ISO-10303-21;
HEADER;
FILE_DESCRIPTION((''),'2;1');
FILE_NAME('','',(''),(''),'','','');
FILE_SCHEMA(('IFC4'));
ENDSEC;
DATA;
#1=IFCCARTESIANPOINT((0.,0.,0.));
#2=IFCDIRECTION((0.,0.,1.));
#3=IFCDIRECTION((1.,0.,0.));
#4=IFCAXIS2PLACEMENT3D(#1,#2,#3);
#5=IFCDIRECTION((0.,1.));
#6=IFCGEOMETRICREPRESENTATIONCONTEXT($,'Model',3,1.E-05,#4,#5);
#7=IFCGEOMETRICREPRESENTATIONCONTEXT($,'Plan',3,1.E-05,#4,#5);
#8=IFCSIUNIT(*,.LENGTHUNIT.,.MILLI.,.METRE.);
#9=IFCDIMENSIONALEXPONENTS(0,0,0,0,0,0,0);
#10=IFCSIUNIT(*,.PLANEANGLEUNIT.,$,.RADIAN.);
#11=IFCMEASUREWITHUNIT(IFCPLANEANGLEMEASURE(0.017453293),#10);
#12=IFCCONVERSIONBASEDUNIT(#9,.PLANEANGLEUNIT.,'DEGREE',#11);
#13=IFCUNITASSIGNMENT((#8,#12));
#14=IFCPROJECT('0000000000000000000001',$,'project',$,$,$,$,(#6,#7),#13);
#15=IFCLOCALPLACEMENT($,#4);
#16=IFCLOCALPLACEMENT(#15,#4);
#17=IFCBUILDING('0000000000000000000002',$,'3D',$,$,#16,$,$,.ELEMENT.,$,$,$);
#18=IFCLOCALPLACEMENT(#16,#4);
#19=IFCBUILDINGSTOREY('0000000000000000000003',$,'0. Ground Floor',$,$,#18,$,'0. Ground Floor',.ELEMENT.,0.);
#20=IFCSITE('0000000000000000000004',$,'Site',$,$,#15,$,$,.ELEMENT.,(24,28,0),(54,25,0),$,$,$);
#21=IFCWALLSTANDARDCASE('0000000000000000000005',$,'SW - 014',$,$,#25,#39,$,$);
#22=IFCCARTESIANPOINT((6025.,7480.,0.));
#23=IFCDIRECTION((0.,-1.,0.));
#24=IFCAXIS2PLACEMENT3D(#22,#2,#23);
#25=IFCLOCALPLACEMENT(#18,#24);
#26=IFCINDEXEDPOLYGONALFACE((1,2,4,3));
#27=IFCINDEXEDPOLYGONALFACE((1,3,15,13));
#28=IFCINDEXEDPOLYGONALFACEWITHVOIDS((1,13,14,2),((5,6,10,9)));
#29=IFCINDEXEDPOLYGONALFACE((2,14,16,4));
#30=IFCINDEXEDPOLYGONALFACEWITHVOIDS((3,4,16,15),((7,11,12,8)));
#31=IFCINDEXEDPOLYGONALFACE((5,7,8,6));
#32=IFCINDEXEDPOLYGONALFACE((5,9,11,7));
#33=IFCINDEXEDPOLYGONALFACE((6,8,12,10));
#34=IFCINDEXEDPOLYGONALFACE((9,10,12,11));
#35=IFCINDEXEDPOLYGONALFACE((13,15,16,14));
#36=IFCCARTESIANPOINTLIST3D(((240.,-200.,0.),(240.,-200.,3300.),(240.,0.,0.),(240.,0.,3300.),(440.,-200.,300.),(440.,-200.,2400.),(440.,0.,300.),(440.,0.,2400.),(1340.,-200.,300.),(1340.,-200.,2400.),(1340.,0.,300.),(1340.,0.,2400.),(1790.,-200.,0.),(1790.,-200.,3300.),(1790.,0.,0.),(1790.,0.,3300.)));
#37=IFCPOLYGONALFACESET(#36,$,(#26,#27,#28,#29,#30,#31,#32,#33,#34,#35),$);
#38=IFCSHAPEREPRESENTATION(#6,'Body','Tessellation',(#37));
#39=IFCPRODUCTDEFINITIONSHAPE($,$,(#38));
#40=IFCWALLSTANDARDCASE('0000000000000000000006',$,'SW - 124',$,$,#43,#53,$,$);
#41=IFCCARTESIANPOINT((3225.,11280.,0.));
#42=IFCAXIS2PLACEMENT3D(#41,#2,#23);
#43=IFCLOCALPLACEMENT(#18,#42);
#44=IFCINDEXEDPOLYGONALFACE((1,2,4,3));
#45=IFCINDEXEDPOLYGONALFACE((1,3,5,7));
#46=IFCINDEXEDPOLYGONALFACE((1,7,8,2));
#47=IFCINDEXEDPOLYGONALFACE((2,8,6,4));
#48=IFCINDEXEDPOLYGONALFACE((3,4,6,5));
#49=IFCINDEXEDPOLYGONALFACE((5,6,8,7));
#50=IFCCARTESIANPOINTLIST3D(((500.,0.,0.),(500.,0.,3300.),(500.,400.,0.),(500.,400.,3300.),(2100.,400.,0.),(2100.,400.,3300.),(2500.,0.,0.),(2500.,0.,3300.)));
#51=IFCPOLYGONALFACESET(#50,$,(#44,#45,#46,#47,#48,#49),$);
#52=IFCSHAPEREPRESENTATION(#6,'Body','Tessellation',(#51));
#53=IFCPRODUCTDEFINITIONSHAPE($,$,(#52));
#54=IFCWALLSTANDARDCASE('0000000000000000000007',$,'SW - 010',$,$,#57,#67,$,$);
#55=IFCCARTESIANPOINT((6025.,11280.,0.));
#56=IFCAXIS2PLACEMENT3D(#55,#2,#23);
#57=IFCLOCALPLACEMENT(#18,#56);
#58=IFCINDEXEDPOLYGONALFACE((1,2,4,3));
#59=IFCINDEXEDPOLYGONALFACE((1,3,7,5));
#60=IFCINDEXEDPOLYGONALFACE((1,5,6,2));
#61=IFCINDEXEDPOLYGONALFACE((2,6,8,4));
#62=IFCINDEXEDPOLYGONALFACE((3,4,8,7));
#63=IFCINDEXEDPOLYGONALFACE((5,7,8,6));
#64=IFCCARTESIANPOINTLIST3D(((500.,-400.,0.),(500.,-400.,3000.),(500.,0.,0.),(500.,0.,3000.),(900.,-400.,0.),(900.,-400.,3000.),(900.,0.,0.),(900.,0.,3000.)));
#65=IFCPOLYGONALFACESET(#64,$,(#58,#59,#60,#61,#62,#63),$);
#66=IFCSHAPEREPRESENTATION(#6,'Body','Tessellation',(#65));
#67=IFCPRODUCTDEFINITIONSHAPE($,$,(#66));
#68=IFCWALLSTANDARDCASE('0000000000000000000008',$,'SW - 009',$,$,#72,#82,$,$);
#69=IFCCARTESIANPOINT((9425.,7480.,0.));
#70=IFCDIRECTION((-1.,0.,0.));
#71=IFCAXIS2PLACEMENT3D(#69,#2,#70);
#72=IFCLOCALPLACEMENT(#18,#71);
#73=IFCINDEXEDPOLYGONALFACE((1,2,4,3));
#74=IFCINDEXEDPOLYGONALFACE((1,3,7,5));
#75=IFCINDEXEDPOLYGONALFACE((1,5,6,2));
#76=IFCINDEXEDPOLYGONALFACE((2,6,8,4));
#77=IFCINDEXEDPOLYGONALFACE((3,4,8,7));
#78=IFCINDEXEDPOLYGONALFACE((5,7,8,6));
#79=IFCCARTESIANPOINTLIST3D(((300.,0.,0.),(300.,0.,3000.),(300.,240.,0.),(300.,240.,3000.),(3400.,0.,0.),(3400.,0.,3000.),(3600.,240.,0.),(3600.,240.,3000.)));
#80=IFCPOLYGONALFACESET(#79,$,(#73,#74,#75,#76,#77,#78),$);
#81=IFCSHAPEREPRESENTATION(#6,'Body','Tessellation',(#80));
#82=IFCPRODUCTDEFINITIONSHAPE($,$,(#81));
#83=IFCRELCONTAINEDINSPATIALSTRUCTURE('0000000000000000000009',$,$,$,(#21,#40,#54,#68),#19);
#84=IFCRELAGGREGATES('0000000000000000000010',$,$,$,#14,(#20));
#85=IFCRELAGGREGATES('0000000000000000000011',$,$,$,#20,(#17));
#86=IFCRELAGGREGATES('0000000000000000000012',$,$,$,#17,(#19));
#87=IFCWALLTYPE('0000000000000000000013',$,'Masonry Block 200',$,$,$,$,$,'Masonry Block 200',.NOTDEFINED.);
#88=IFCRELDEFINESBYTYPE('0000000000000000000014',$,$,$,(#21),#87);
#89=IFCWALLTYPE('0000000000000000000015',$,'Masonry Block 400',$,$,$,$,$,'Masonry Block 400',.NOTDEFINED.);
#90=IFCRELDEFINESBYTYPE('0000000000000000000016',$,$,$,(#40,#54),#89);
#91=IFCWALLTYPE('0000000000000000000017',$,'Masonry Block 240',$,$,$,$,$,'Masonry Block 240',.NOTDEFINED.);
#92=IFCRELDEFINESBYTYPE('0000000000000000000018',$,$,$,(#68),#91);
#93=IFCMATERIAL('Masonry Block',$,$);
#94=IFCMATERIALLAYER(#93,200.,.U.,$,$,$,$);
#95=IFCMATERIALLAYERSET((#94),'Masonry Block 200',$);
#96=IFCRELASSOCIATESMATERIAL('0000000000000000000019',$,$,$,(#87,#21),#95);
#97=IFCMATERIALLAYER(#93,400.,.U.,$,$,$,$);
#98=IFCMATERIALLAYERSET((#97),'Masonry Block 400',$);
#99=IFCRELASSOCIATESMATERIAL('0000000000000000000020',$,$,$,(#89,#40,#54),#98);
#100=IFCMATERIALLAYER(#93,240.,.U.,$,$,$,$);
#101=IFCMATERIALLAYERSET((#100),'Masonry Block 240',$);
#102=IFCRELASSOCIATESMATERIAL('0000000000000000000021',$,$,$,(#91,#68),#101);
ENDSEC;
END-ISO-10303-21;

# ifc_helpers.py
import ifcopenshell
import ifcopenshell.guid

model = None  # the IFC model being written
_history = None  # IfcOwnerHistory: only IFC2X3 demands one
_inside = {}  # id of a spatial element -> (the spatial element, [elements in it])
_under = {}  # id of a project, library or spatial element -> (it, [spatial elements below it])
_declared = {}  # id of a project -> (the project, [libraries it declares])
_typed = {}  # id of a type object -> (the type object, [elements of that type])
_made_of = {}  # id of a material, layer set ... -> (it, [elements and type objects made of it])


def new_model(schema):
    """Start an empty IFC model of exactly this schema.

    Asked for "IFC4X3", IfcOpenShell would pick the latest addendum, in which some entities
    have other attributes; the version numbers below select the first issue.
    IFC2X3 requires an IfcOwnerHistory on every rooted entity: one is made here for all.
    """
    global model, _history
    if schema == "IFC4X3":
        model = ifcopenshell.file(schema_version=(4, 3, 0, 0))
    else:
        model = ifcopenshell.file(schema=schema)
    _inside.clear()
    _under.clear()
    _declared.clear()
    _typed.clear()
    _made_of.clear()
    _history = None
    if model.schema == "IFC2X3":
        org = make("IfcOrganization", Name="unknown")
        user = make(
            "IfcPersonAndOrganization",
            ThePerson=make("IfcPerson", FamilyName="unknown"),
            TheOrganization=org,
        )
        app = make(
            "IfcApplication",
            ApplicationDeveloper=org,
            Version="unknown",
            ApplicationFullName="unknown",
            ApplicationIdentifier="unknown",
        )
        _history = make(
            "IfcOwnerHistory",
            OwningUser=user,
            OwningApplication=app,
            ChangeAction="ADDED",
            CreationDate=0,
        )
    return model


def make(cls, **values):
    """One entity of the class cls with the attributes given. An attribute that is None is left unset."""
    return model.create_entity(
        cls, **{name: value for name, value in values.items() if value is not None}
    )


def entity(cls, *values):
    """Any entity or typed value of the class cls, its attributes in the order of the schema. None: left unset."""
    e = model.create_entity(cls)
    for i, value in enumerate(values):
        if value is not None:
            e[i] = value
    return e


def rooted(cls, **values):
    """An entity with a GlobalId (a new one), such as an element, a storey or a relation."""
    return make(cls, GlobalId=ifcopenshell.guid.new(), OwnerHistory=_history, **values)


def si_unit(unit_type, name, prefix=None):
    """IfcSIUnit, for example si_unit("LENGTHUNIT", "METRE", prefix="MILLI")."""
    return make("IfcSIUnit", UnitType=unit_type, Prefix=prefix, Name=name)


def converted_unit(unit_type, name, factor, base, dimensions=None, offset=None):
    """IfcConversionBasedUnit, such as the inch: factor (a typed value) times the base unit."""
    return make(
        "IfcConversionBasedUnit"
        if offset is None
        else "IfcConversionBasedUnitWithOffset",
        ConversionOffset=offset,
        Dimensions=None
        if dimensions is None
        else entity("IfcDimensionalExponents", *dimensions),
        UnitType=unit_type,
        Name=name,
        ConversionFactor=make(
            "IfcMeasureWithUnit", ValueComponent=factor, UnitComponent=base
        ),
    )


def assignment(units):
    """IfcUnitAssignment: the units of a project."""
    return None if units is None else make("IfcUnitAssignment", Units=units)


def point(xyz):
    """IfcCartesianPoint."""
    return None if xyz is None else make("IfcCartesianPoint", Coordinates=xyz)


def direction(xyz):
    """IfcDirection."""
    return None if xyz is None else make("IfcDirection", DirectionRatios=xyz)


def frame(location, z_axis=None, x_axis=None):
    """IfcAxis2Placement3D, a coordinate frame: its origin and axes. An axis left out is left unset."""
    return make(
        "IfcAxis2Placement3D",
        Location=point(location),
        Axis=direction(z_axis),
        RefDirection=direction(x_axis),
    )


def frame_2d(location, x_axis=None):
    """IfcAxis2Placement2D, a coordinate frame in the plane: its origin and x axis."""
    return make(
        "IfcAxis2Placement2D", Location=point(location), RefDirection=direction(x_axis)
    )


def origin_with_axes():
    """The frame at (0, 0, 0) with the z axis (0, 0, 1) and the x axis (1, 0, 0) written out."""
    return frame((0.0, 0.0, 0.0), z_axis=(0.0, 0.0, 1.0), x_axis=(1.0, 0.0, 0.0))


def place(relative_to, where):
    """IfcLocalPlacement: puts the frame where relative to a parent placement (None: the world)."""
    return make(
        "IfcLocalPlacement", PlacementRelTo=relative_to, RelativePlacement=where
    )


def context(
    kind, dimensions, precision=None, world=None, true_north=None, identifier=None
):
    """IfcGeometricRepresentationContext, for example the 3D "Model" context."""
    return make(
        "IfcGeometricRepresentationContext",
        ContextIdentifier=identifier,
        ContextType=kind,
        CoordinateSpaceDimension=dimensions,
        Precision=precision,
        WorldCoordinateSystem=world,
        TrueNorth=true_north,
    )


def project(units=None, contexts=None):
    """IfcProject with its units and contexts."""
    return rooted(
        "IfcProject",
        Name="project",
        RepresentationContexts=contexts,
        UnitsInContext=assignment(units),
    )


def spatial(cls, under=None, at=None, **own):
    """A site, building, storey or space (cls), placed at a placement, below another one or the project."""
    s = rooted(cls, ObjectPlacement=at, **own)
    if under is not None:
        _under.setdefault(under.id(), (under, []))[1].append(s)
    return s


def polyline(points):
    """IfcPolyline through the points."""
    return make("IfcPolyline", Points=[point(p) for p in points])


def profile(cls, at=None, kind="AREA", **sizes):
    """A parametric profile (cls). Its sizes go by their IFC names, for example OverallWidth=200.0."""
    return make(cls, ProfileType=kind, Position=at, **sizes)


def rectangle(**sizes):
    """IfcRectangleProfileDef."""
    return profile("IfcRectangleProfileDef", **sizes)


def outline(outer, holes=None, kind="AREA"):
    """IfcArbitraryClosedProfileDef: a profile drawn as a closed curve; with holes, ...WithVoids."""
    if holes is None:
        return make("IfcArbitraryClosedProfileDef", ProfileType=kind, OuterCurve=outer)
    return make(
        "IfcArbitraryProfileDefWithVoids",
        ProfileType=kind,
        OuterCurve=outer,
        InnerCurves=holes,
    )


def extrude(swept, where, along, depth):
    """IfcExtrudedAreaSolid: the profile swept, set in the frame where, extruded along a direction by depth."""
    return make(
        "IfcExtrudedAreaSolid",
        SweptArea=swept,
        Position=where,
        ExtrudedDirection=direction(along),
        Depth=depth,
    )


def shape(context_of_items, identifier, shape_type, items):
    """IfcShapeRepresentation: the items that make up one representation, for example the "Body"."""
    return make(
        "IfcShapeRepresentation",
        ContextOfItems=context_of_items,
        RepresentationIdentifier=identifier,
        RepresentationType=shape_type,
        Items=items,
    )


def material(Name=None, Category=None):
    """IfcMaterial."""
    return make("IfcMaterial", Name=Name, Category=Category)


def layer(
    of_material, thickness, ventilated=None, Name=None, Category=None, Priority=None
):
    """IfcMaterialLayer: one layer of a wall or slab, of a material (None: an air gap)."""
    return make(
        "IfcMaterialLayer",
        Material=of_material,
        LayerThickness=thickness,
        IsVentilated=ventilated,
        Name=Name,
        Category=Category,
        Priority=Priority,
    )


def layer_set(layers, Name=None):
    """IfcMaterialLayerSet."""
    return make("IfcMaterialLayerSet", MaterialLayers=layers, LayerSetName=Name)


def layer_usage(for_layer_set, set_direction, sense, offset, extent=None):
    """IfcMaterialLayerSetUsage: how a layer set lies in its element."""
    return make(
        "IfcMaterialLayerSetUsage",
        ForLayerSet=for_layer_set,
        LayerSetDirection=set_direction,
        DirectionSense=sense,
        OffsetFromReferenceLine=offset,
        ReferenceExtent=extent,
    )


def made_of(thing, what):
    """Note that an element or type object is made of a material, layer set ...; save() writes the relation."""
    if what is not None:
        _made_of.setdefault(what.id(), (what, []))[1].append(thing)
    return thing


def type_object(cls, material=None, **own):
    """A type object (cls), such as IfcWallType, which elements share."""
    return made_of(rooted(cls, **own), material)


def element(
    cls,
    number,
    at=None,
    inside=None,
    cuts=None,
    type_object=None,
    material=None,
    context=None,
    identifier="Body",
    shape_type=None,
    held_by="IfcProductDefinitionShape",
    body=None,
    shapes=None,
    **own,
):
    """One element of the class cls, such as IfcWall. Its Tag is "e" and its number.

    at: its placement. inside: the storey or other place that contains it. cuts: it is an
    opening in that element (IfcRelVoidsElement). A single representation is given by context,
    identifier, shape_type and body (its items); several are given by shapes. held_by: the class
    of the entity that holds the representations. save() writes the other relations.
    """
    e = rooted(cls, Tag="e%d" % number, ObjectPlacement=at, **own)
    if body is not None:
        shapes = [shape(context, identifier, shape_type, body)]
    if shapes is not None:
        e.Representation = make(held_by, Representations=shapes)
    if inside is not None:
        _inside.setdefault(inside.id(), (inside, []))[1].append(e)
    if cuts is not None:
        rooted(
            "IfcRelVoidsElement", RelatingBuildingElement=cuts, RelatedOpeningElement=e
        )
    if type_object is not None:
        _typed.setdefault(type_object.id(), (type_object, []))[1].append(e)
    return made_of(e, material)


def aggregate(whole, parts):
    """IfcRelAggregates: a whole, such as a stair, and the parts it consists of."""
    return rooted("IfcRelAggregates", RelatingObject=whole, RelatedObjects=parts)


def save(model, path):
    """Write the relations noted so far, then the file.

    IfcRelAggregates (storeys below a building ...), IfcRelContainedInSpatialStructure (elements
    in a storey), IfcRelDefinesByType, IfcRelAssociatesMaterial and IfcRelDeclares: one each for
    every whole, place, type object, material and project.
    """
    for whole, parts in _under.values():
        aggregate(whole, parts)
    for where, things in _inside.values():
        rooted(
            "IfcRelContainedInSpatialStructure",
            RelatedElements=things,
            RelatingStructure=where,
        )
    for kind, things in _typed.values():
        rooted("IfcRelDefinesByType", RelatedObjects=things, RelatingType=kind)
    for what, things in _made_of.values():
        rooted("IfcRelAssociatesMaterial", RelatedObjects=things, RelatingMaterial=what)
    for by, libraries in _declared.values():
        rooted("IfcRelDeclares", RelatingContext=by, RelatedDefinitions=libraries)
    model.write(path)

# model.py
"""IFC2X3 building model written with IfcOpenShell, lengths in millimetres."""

from ifc_helpers import new_model, entity, si_unit, converted_unit, direction, frame, frame_2d, origin_with_axes, place, context, project, spatial, polyline, rectangle, outline, extrude, material, layer, layer_set, layer_usage, type_object, element, save


model = new_model("IFC2X3")

# Units and contexts
model_context = context("Model", 3, precision=1e-05, world=origin_with_axes(), true_north=direction((0.0, 1.0)))
plan_context = context("Plan", 3, precision=1e-05, world=origin_with_axes(), true_north=direction((0.0, 1.0)))
ifc_project = project(units=[si_unit("LENGTHUNIT", "METRE", prefix="MILLI"), converted_unit("PLANEANGLEUNIT", "DEGREE", entity("IfcPlaneAngleMeasure", 0.017453293), si_unit("PLANEANGLEUNIT", "RADIAN"), dimensions=[0, 0, 0, 0, 0, 0, 0])], contexts=[model_context, plan_context])

# Site, building, storey
site_placement = place(None, origin_with_axes())
site = spatial("IfcSite", under=ifc_project, at=site_placement, Name="Site", CompositionType="ELEMENT", RefLatitude=(24, 28, 0), RefLongitude=(54, 25, 0))
building_placement = place(site_placement, origin_with_axes())
building = spatial("IfcBuilding", under=site, at=building_placement, Name="3D", CompositionType="ELEMENT")
storey_placement = place(building_placement, origin_with_axes())
storey = spatial("IfcBuildingStorey", under=building, at=storey_placement, Name="0. Ground Floor", LongName="0. Ground Floor", CompositionType="ELEMENT", Elevation=0.0)

# Shared definitions
ifc_material_1 = material(Name="Masonry Block")
ifc_layer_1 = layer(ifc_material_1, 200.0, ventilated="UNKNOWN")
ifc_layer_set_1 = layer_set([ifc_layer_1], Name="Masonry Block 200")

# Wall, opening
wall_type_1 = type_object("IfcWallType", Name="Masonry Block 200", ElementType="Masonry Block 200", PredefinedType="NOTDEFINED", material=ifc_layer_set_1)
ifc_layer_usage_1 = layer_usage(ifc_layer_set_1, "AXIS2", "NEGATIVE", 0.0)
wall_1_placement = place(storey_placement, frame((6025.0, 7480.0, 0.0), z_axis=(0.0, 0.0, 1.0), x_axis=(0.0, -1.0, 0.0)))
wall_1 = element("IfcWallStandardCase", 1, at=wall_1_placement, inside=storey, type_object=wall_type_1, material=ifc_layer_usage_1, Name="SW - 014", context=model_context, shape_type="SweptSolid", body=[
    extrude(outline(polyline([(240.0, -200.0), (1790.0, -200.0), (1790.0, 0.0), (240.0, 0.0), (240.0, -200.0)])), origin_with_axes(), (0.0, 0.0, 1.0), 3300.0),
])
opening_1_placement = place(wall_1_placement, frame((890.0, -200.0, 300.0), z_axis=(0.0, 0.0, 1.0), x_axis=(1.0, 0.0, 0.0)))
element("IfcOpeningElement", 2, at=opening_1_placement, cuts=wall_1, ObjectType="Opening", context=model_context, shape_type="SweptSolid", body=[
    extrude(rectangle(XDim=900.0, YDim=2100.0, at=frame_2d((0.0, 1050.0), x_axis=(1.0, 0.0))), frame((0.0, 0.0, 0.0), z_axis=(0.0, 1.0, 0.0), x_axis=(-1.0, 0.0, 0.0)), (0.0, 0.0, 1.0), 200.0),
])

# Walls
ifc_layer_2 = layer(ifc_material_1, 400.0, ventilated="UNKNOWN")
ifc_layer_set_2 = layer_set([ifc_layer_2], Name="Masonry Block 400")
ifc_layer_usage_2 = layer_usage(ifc_layer_set_2, "AXIS2", "POSITIVE", 0.0)
wall_type_2 = type_object("IfcWallType", Name="Masonry Block 400", ElementType="Masonry Block 400", PredefinedType="NOTDEFINED", material=ifc_layer_set_2)
wall_2_placement = place(storey_placement, frame((3225.0, 11280.0, 0.0), z_axis=(0.0, 0.0, 1.0), x_axis=(0.0, -1.0, 0.0)))
element("IfcWallStandardCase", 3, at=wall_2_placement, inside=storey, type_object=wall_type_2, material=ifc_layer_usage_2, Name="SW - 124", context=model_context, shape_type="SweptSolid", body=[
    extrude(outline(polyline([(500.0, 0.0), (2500.0, 0.0), (2100.0, 400.0), (500.0, 400.0), (500.0, 0.0)])), origin_with_axes(), (0.0, 0.0, 1.0), 3300.0),
])
ifc_layer_usage_3 = layer_usage(ifc_layer_set_2, "AXIS2", "NEGATIVE", 0.0)
wall_3_placement = place(storey_placement, frame((6025.0, 11280.0, 0.0), z_axis=(0.0, 0.0, 1.0), x_axis=(0.0, -1.0, 0.0)))
element("IfcWallStandardCase", 4, at=wall_3_placement, inside=storey, type_object=wall_type_2, material=ifc_layer_usage_3, Name="SW - 010", context=model_context, shape_type="SweptSolid", body=[
    extrude(outline(polyline([(500.0, -400.0), (900.0, -400.0), (900.0, 0.0), (500.0, 0.0), (500.0, -400.0)])), origin_with_axes(), (0.0, 0.0, 1.0), 3000.0),
])
ifc_layer_3 = layer(ifc_material_1, 240.0, ventilated="UNKNOWN")
ifc_layer_set_3 = layer_set([ifc_layer_3], Name="Masonry Block 240")
wall_type_3 = type_object("IfcWallType", Name="Masonry Block 240", ElementType="Masonry Block 240", PredefinedType="NOTDEFINED", material=ifc_layer_set_3)
ifc_layer_usage_4 = layer_usage(ifc_layer_set_3, "AXIS2", "POSITIVE", 0.0)
wall_4_placement = place(storey_placement, frame((9425.0, 7480.0, 0.0), z_axis=(0.0, 0.0, 1.0), x_axis=(-1.0, 0.0, 0.0)))
element("IfcWallStandardCase", 5, at=wall_4_placement, inside=storey, type_object=wall_type_3, material=ifc_layer_usage_4, Name="SW - 009", context=model_context, shape_type="SweptSolid", body=[
    extrude(outline(polyline([(300.0, 0.0), (3400.0, 0.0), (3600.0, 240.0), (300.0, 240.0), (300.0, 0.0)])), origin_with_axes(), (0.0, 0.0, 1.0), 3000.0),
])

save(model, "model.ifc")
